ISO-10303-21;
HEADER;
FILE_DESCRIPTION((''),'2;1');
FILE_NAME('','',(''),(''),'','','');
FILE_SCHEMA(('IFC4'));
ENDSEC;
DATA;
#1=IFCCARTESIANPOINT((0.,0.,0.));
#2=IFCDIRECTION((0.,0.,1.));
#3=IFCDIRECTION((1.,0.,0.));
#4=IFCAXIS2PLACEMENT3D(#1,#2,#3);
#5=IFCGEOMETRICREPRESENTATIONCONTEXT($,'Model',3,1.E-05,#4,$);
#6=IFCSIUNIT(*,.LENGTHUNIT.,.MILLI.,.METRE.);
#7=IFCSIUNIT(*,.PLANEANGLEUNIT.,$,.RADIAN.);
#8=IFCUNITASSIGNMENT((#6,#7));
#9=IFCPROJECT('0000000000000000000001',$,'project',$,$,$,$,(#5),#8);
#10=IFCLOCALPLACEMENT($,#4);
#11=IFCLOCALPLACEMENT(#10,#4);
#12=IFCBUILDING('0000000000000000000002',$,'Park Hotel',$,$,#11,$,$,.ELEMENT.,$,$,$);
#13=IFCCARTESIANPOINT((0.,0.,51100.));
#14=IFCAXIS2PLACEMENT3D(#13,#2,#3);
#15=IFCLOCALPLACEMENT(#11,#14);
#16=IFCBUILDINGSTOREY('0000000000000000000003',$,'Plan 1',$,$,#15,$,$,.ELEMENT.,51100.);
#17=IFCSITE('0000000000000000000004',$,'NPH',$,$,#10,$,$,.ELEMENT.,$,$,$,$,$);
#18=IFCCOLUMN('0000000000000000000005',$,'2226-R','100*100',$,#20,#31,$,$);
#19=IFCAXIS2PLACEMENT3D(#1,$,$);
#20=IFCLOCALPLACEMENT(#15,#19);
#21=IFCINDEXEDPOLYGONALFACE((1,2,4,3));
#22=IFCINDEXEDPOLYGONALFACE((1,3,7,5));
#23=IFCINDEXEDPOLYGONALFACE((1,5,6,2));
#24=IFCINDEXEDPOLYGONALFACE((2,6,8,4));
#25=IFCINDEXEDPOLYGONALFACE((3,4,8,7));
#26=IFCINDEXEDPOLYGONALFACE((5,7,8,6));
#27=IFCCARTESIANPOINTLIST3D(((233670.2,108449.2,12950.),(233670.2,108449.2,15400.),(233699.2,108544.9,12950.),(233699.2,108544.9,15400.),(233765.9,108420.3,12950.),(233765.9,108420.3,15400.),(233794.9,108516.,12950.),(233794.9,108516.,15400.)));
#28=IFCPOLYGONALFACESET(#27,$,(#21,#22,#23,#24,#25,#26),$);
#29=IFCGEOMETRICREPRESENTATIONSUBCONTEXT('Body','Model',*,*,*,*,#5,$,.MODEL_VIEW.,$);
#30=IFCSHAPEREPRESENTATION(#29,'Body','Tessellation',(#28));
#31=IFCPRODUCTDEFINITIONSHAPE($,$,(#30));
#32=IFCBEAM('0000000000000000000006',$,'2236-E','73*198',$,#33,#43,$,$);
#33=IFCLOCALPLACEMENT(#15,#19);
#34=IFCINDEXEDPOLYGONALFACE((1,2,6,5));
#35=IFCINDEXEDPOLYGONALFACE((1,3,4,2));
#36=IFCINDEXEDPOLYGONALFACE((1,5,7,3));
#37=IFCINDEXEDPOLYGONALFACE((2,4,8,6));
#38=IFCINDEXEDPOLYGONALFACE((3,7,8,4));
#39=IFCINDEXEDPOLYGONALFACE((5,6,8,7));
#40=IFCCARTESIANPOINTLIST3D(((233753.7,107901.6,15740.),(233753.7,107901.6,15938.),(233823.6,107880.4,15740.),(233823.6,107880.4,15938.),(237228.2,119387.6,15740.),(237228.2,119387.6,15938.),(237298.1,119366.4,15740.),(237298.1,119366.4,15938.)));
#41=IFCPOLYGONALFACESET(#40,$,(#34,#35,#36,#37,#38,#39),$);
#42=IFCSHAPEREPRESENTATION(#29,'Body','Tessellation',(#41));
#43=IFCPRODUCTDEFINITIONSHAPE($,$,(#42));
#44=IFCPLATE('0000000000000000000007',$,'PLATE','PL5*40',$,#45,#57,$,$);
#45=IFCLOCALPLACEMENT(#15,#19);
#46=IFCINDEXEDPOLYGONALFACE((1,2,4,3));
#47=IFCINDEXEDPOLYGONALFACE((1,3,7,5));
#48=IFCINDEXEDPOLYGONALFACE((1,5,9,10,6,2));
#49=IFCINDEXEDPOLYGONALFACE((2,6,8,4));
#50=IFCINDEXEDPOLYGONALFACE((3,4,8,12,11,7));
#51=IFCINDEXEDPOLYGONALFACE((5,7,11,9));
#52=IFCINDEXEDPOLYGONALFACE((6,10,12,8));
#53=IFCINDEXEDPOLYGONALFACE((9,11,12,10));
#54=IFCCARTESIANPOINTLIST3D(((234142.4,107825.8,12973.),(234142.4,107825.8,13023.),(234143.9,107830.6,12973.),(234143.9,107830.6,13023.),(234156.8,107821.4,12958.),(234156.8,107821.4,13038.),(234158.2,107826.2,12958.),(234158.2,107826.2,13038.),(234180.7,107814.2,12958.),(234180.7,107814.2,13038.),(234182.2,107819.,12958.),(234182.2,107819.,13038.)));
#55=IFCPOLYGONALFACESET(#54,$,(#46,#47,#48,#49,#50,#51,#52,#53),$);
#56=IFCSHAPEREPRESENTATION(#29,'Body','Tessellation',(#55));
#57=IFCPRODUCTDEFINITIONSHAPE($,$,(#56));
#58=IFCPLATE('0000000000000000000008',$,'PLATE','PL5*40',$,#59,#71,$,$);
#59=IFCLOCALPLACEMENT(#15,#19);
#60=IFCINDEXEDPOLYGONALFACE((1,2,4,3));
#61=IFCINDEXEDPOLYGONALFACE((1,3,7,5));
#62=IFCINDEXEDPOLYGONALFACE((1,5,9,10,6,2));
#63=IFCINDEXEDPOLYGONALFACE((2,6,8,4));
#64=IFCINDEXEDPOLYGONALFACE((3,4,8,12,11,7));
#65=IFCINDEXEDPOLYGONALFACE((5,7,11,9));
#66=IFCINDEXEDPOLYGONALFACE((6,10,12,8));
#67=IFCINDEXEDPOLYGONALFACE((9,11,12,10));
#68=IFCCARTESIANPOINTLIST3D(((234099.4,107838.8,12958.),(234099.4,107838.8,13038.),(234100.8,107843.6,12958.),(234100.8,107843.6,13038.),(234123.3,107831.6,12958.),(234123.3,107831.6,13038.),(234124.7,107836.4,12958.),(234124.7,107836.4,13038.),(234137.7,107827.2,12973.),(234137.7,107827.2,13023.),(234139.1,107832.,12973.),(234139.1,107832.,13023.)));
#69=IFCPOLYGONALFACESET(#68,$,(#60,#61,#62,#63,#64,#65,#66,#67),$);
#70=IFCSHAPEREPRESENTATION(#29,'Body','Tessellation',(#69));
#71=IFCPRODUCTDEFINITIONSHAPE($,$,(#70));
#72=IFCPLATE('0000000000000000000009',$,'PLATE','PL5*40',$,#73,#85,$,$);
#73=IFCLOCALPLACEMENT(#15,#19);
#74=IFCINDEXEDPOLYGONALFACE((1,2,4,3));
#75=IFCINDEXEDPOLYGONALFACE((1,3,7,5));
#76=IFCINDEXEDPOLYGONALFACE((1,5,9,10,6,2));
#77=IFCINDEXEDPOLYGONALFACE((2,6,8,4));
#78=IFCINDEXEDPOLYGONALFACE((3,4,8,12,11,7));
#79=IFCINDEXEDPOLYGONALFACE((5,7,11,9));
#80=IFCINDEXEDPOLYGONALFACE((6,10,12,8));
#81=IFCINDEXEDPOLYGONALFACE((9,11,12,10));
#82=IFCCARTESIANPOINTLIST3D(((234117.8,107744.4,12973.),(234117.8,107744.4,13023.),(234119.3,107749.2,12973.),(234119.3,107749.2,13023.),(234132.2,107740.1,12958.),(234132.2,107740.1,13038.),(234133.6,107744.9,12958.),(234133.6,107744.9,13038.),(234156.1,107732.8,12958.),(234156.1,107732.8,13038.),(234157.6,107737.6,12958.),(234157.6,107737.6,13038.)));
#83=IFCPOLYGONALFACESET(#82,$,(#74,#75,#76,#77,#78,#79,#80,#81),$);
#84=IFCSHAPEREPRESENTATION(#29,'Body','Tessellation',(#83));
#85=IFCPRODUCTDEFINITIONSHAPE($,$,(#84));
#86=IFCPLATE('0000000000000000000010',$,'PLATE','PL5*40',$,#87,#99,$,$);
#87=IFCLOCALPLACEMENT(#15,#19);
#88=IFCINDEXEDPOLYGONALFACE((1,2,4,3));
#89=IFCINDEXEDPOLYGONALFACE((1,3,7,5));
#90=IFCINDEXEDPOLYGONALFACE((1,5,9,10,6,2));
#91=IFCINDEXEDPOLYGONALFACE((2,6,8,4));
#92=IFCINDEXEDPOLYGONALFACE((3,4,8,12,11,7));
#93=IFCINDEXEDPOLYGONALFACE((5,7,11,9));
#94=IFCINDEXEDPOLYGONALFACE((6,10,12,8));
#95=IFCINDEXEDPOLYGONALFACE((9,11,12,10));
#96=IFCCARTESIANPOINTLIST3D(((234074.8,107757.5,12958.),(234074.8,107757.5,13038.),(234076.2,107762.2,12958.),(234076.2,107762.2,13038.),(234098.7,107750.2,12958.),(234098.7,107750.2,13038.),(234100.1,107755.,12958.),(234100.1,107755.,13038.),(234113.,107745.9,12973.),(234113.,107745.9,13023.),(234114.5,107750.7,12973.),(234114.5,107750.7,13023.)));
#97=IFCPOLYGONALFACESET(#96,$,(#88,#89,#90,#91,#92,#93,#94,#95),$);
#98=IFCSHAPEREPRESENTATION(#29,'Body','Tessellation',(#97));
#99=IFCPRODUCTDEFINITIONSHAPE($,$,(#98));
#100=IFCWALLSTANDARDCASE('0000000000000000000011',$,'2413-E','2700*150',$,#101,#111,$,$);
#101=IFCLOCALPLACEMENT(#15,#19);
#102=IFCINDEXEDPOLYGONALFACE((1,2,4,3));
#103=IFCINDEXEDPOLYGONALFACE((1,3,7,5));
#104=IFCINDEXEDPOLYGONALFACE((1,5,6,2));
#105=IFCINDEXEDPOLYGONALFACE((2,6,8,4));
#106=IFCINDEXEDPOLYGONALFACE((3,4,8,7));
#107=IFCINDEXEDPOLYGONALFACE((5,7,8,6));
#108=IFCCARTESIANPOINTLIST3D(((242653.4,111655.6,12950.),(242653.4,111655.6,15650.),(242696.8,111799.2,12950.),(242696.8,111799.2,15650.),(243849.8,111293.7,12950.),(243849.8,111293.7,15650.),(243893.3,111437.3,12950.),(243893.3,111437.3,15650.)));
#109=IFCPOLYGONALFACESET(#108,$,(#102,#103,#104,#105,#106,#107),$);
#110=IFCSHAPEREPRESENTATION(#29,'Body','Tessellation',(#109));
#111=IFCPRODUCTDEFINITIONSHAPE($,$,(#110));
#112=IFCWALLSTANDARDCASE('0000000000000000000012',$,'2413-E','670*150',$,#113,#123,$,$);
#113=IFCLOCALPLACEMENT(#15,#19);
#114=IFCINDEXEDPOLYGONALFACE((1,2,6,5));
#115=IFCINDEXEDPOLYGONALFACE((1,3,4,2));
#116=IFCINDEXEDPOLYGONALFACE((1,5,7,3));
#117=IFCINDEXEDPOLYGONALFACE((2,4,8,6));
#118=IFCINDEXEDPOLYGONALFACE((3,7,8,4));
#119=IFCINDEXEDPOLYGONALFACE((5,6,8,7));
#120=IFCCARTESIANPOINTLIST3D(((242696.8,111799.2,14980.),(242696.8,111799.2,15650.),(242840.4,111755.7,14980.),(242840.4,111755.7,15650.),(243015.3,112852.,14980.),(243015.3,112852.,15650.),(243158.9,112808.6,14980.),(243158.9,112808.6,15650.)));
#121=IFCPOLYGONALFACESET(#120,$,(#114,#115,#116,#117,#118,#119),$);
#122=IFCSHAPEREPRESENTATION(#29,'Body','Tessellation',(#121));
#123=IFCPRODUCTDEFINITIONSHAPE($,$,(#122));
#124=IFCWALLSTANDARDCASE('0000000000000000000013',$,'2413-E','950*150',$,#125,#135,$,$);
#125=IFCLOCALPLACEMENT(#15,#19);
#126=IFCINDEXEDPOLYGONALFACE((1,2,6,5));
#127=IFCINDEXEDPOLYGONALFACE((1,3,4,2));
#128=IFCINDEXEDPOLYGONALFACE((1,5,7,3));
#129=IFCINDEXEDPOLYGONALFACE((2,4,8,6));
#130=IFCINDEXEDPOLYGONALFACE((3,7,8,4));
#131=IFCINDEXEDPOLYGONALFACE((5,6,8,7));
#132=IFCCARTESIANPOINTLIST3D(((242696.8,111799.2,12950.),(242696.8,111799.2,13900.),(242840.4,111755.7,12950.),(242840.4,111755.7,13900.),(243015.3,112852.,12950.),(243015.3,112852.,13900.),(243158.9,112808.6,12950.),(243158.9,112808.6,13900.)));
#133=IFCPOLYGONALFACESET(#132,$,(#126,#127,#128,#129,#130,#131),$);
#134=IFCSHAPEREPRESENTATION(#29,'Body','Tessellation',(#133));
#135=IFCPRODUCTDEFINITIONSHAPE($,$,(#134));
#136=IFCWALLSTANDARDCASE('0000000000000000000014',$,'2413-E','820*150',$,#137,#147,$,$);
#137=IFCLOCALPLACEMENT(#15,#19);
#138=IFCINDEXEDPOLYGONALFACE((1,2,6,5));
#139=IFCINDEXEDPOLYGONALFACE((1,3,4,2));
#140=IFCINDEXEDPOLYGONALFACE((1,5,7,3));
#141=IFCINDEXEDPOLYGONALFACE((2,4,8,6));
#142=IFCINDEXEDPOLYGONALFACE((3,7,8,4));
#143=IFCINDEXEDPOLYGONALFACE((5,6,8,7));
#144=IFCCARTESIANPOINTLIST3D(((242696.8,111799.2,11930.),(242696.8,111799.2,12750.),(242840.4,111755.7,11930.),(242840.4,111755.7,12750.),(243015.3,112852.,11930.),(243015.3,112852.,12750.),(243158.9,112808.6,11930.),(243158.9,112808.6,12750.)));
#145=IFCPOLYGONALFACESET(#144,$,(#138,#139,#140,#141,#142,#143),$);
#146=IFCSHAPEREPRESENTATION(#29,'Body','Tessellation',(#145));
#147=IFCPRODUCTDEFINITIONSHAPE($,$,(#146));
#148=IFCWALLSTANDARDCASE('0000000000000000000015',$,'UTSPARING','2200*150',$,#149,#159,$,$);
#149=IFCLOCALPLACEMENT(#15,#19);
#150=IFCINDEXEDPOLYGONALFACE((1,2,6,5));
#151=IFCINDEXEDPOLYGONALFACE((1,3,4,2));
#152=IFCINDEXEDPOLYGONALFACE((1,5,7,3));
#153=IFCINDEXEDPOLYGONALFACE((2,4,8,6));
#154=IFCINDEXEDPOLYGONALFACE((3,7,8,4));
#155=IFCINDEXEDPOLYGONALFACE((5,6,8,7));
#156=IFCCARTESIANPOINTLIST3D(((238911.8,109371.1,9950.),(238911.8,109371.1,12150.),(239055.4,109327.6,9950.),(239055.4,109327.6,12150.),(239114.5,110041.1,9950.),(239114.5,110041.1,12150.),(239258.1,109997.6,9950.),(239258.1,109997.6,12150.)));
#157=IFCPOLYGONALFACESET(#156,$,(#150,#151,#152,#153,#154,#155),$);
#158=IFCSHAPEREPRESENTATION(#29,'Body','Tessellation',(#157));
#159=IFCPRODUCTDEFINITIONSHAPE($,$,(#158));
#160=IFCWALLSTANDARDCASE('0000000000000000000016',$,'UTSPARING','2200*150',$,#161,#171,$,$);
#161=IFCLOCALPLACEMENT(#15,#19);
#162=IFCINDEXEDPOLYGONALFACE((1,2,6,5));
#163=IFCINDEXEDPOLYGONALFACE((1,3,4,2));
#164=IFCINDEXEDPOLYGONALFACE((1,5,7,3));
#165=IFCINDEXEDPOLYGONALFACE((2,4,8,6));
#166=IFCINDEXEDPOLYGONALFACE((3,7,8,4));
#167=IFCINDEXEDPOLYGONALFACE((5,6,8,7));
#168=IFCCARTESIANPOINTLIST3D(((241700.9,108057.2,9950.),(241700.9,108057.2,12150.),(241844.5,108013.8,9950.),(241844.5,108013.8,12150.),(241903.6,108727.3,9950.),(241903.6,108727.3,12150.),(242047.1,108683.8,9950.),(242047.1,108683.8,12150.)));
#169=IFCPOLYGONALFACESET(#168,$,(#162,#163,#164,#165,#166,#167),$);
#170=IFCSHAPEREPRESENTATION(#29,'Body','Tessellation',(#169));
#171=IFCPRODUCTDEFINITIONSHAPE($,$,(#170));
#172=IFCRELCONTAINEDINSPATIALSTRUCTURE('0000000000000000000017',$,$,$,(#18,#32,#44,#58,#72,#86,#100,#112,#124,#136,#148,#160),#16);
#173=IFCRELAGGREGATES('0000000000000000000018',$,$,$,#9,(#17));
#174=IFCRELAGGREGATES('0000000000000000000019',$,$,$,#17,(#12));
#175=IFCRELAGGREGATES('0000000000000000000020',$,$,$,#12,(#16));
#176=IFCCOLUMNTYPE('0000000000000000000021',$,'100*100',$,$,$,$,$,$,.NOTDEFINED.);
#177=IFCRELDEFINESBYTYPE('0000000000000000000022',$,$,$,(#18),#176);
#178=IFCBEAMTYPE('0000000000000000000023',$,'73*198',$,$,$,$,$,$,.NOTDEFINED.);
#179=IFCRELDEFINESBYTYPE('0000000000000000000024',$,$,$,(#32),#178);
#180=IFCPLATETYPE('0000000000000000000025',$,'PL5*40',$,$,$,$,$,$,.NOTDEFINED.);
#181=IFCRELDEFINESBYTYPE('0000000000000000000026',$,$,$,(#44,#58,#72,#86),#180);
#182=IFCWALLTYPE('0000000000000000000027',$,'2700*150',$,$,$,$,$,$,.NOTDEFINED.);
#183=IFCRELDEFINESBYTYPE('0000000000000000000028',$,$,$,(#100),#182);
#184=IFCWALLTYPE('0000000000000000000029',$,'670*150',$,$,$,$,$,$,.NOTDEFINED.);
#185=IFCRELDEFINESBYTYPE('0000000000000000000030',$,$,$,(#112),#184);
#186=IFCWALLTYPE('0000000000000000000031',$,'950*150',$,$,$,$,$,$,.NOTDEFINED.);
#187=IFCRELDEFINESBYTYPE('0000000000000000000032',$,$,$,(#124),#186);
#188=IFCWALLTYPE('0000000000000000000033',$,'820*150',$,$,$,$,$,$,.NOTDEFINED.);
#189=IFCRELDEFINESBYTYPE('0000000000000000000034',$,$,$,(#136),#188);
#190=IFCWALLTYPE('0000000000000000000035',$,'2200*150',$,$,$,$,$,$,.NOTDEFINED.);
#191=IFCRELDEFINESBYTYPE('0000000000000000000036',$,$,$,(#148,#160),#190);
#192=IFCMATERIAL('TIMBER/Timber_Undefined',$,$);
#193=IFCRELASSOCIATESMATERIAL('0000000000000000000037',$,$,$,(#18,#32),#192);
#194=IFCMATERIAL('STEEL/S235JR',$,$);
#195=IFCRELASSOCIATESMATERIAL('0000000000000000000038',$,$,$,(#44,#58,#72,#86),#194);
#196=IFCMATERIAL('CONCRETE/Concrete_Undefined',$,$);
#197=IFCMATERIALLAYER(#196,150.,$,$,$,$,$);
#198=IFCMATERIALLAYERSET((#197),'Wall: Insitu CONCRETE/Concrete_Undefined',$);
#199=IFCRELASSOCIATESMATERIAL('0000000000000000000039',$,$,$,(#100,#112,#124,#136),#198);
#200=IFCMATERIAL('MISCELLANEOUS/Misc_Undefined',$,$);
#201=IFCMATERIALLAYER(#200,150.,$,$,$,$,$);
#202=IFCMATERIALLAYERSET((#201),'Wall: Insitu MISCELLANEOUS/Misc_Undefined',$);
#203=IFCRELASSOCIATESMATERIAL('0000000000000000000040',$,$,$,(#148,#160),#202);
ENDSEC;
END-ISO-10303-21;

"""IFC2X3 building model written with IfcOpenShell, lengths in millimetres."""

from ifc_helpers import new_model, si_unit, frame, frame_2d, origin_with_axes, origin_2d_with_axis, place, context, subcontext, project, spatial, polyline, rectangle, outline, extrude, material, layer, layer_set, layer_usage, type_object, element, save


model = new_model("IFC2X3")

# Units and contexts
model_context = context("Model", 3, precision=1e-05, world=origin_with_axes())
body_context = subcontext(model_context, "Body", "Model", "MODEL_VIEW")
ifc_project = project(units=[si_unit("LENGTHUNIT", "METRE", prefix="MILLI"), si_unit("PLANEANGLEUNIT", "RADIAN")], contexts=[model_context])

# Site, building, storey
site_placement = place(None, origin_with_axes())
site = spatial("IfcSite", under=ifc_project, at=site_placement, Name="NPH", CompositionType="ELEMENT")
building_placement = place(site_placement, origin_with_axes())
building = spatial("IfcBuilding", under=site, at=building_placement, Name="Park Hotel", CompositionType="ELEMENT")
storey_placement = place(building_placement, frame((0.0, 0.0, 51100.0), z_axis=(0.0, 0.0, 1.0), x_axis=(1.0, 0.0, 0.0)))
storey = spatial("IfcBuildingStorey", under=building, at=storey_placement, Name="Plan 1", CompositionType="ELEMENT", Elevation=51100.0)

# Column
ifc_material_1 = material(Name="TIMBER/Timber_Undefined")
column_type = type_object("IfcColumnType", Name="100*100", PredefinedType="NOTDEFINED")
column_placement = place(storey_placement, frame((233732.6, 108482.6, 15400.0), z_axis=(0.0, 0.0, -1.0), x_axis=(0.289538, 0.957167, 0.0)))
element("IfcColumn", 1, at=column_placement, inside=storey, type_object=column_type, material=ifc_material_1, Name="2226-R", Description="100*100", context=body_context, shape_type="SweptSolid", body=[
    extrude(rectangle(XDim=100.0, YDim=100.0, at=origin_2d_with_axis()), frame((0.0, 0.0, 2450.0), z_axis=(0.0, 0.0, -1.0), x_axis=(0.0, 1.0, 0.0)), (0.0, 0.0, 1.0), 2450.0),
])

# Beam
beam_type_1 = type_object("IfcBeamType", Name="73*198", PredefinedType="NOTDEFINED")
beam_placement = place(storey_placement, frame((233788.7, 107891.0, 15839.0), z_axis=(-0.957167, 0.289538, 0.0), x_axis=(0.289538, 0.957167, 0.0)))
element("IfcBeam", 2, at=beam_placement, inside=storey, type_object=beam_type_1, material=ifc_material_1, Name="2236-E", Description="73*198", context=body_context, shape_type="SweptSolid", body=[
    extrude(rectangle(XDim=198.0, YDim=73.0, at=origin_2d_with_axis()), frame((12000.0, 0.0, 0.0), z_axis=(-1.0, 0.0, 0.0), x_axis=(0.0, -1.0, 0.0)), (0.0, 0.0, 1.0), 12000.0),
])

# Plates
ifc_material_2 = material(Name="STEEL/S235JR")
plate_type = type_object("IfcPlateType", Name="PL5*40", PredefinedType="NOTDEFINED")
plate_1_placement = place(storey_placement, frame((234181.5, 107816.6, 12958.0), z_axis=(0.289538, 0.957167, 0.0), x_axis=(-0.957167, 0.289538, 0.0)))
element("IfcPlate", 3, at=plate_1_placement, inside=storey, type_object=plate_type, material=ifc_material_2, Name="PLATE", Description="PL5*40", context=body_context, shape_type="SweptSolid", body=[
    extrude(outline(polyline([(0.0, 0.0), (25.0, 0.0), (40.0, 15.0), (40.0, 65.0), (25.0, 80.0), (0.0, 80.0), (0.0, 0.0)])), frame((0.0, 0.0, -2.5), z_axis=(0.0, 0.0, 1.0), x_axis=(1.0, 0.0, 0.0)), (0.0, 0.0, 1.0), 5.0),
])
plate_2_placement = place(storey_placement, frame((234138.4, 107829.6, 12958.0), z_axis=(0.289538, 0.957167, 0.0), x_axis=(-0.957167, 0.289538, 0.0)))
element("IfcPlate", 4, at=plate_2_placement, inside=storey, type_object=plate_type, material=ifc_material_2, Name="PLATE", Description="PL5*40", context=body_context, shape_type="SweptSolid", body=[
    extrude(outline(polyline([(0.0, 15.0), (15.0, 0.0), (40.0, 0.0), (40.0, 80.0), (15.0, 80.0), (0.0, 65.0), (0.0, 15.0)])), frame((0.0, 0.0, -2.5), z_axis=(0.0, 0.0, 1.0), x_axis=(1.0, 0.0, 0.0)), (0.0, 0.0, 1.0), 5.0),
])
plate_3_placement = place(storey_placement, frame((234156.8, 107735.2, 12958.0), z_axis=(0.289538, 0.957167, 0.0), x_axis=(-0.957167, 0.289538, 0.0)))
element("IfcPlate", 5, at=plate_3_placement, inside=storey, type_object=plate_type, material=ifc_material_2, Name="PLATE", Description="PL5*40", context=body_context, shape_type="SweptSolid", body=[
    extrude(outline(polyline([(0.0, 0.0), (25.0, 0.0), (40.0, 15.0), (40.0, 65.0), (25.0, 80.0), (0.0, 80.0), (0.0, 0.0)])), frame((0.0, 0.0, -2.5), z_axis=(0.0, 0.0, 1.0), x_axis=(1.0, 0.0, 0.0)), (0.0, 0.0, 1.0), 5.0),
])
plate_4_placement = place(storey_placement, frame((234113.8, 107748.3, 12958.0), z_axis=(0.289538, 0.957167, 0.0), x_axis=(-0.957167, 0.289538, 0.0)))
element("IfcPlate", 6, at=plate_4_placement, inside=storey, type_object=plate_type, material=ifc_material_2, Name="PLATE", Description="PL5*40", context=body_context, shape_type="SweptSolid", body=[
    extrude(outline(polyline([(0.0, 15.0), (15.0, 0.0), (40.0, 0.0), (40.0, 80.0), (15.0, 80.0), (0.0, 65.0), (0.0, 15.0)])), frame((0.0, 0.0, -2.5), z_axis=(0.0, 0.0, 1.0), x_axis=(1.0, 0.0, 0.0)), (0.0, 0.0, 1.0), 5.0),
])

# Walls
ifc_material_3 = material(Name="CONCRETE/Concrete_Undefined")
ifc_layer_1 = layer(ifc_material_3, 150.0)
ifc_layer_set_1 = layer_set([ifc_layer_1], Name="Wall: Insitu CONCRETE/Concrete_Undefined")
ifc_layer_usage_1 = layer_usage(ifc_layer_set_1, "AXIS2", "POSITIVE", -75.0)
wall_type_1 = type_object("IfcWallType", Name="2700*150", PredefinedType="NOTDEFINED")
wall_1_placement = place(storey_placement, frame((242675.1, 111727.4, 12950.0), z_axis=(0.0, 0.0, 1.0), x_axis=(0.957168, -0.289532, 0.0)))
element("IfcWallStandardCase", 7, at=wall_1_placement, inside=storey, type_object=wall_type_1, material=ifc_layer_usage_1, Name="2413-E", Description="2700*150", context=body_context, shape_type="SweptSolid", body=[
    extrude(rectangle(XDim=1250.0, YDim=150.0, at=frame_2d((0.0, 625.0), x_axis=(0.0, -1.0))), frame((0.0, 0.0, 0.0), z_axis=(0.0, 0.0, 1.0), x_axis=(0.0, -1.0, 0.0)), (0.0, 0.0, 1.0), 2700.0),
])
ifc_layer_usage_2 = layer_usage(ifc_layer_set_1, "AXIS2", "POSITIVE", -75.0)
wall_type_2 = type_object("IfcWallType", Name="670*150", PredefinedType="NOTDEFINED")
wall_2_placement = place(storey_placement, frame((242768.6, 111777.4, 14980.0), z_axis=(0.0, 0.0, 1.0), x_axis=(0.289534, 0.957168, 0.0)))
element("IfcWallStandardCase", 8, at=wall_2_placement, inside=storey, type_object=wall_type_2, material=ifc_layer_usage_2, Name="2413-E", Description="670*150", context=body_context, shape_type="SweptSolid", body=[
    extrude(rectangle(XDim=1100.0, YDim=150.0, at=frame_2d((0.0, 550.0), x_axis=(0.0, -1.0))), frame((0.0, 0.0, 0.0), z_axis=(0.0, 0.0, 1.0), x_axis=(0.0, -1.0, 0.0)), (0.0, 0.0, 1.0), 670.0),
])
ifc_layer_usage_3 = layer_usage(ifc_layer_set_1, "AXIS2", "POSITIVE", -75.0)
wall_type_3 = type_object("IfcWallType", Name="950*150", PredefinedType="NOTDEFINED")
wall_3_placement = place(storey_placement, frame((242768.6, 111777.4, 12950.0), z_axis=(0.0, 0.0, 1.0), x_axis=(0.289534, 0.957168, 0.0)))
element("IfcWallStandardCase", 9, at=wall_3_placement, inside=storey, type_object=wall_type_3, material=ifc_layer_usage_3, Name="2413-E", Description="950*150", context=body_context, shape_type="SweptSolid", body=[
    extrude(rectangle(XDim=1100.0, YDim=150.0, at=frame_2d((0.0, 550.0), x_axis=(0.0, -1.0))), frame((0.0, 0.0, 0.0), z_axis=(0.0, 0.0, 1.0), x_axis=(0.0, -1.0, 0.0)), (0.0, 0.0, 1.0), 950.0),
])
ifc_layer_usage_4 = layer_usage(ifc_layer_set_1, "AXIS2", "POSITIVE", -75.0)
wall_type_4 = type_object("IfcWallType", Name="820*150", PredefinedType="NOTDEFINED")
wall_4_placement = place(storey_placement, frame((242768.6, 111777.4, 11930.0), z_axis=(0.0, 0.0, 1.0), x_axis=(0.289534, 0.957168, 0.0)))
element("IfcWallStandardCase", 10, at=wall_4_placement, inside=storey, type_object=wall_type_4, material=ifc_layer_usage_4, Name="2413-E", Description="820*150", context=body_context, shape_type="SweptSolid", body=[
    extrude(rectangle(XDim=1100.0, YDim=150.0, at=frame_2d((0.0, 550.0), x_axis=(0.0, -1.0))), frame((0.0, 0.0, 0.0), z_axis=(0.0, 0.0, 1.0), x_axis=(0.0, -1.0, 0.0)), (0.0, 0.0, 1.0), 820.0),
])
ifc_material_4 = material(Name="MISCELLANEOUS/Misc_Undefined")
ifc_layer_2 = layer(ifc_material_4, 150.0)
ifc_layer_set_2 = layer_set([ifc_layer_2], Name="Wall: Insitu MISCELLANEOUS/Misc_Undefined")
ifc_layer_usage_5 = layer_usage(ifc_layer_set_2, "AXIS2", "POSITIVE", -75.0)
wall_type_5 = type_object("IfcWallType", Name="2200*150", PredefinedType="NOTDEFINED")
wall_5_placement = place(storey_placement, frame((238983.6, 109349.3, 9950.0), z_axis=(0.0, 0.0, 1.0), x_axis=(0.289542, 0.957165, 0.0)))
element("IfcWallStandardCase", 11, at=wall_5_placement, inside=storey, type_object=wall_type_5, material=ifc_layer_usage_5, Name="UTSPARING", Description="2200*150", context=body_context, shape_type="SweptSolid", body=[
    extrude(rectangle(XDim=700.0, YDim=150.0, at=frame_2d((0.0, 350.0), x_axis=(0.0, -1.0))), frame((0.0, 0.0, 0.0), z_axis=(0.0, 0.0, 1.0), x_axis=(0.0, -1.0, 0.0)), (0.0, 0.0, 1.0), 2200.0),
])
ifc_layer_usage_6 = layer_usage(ifc_layer_set_2, "AXIS2", "POSITIVE", -75.0)
wall_6_placement = place(storey_placement, frame((241772.7, 108035.5, 9950.0), z_axis=(0.0, 0.0, 1.0), x_axis=(0.289542, 0.957165, 0.0)))
element("IfcWallStandardCase", 12, at=wall_6_placement, inside=storey, type_object=wall_type_5, material=ifc_layer_usage_6, Name="UTSPARING", Description="2200*150", context=body_context, shape_type="SweptSolid", body=[
    extrude(rectangle(XDim=700.0, YDim=150.0, at=frame_2d((0.0, 350.0), x_axis=(0.0, -1.0))), frame((0.0, 0.0, 0.0), z_axis=(0.0, 0.0, 1.0), x_axis=(0.0, -1.0, 0.0)), (0.0, 0.0, 1.0), 2200.0),
])

save(model, "model.ifc")
